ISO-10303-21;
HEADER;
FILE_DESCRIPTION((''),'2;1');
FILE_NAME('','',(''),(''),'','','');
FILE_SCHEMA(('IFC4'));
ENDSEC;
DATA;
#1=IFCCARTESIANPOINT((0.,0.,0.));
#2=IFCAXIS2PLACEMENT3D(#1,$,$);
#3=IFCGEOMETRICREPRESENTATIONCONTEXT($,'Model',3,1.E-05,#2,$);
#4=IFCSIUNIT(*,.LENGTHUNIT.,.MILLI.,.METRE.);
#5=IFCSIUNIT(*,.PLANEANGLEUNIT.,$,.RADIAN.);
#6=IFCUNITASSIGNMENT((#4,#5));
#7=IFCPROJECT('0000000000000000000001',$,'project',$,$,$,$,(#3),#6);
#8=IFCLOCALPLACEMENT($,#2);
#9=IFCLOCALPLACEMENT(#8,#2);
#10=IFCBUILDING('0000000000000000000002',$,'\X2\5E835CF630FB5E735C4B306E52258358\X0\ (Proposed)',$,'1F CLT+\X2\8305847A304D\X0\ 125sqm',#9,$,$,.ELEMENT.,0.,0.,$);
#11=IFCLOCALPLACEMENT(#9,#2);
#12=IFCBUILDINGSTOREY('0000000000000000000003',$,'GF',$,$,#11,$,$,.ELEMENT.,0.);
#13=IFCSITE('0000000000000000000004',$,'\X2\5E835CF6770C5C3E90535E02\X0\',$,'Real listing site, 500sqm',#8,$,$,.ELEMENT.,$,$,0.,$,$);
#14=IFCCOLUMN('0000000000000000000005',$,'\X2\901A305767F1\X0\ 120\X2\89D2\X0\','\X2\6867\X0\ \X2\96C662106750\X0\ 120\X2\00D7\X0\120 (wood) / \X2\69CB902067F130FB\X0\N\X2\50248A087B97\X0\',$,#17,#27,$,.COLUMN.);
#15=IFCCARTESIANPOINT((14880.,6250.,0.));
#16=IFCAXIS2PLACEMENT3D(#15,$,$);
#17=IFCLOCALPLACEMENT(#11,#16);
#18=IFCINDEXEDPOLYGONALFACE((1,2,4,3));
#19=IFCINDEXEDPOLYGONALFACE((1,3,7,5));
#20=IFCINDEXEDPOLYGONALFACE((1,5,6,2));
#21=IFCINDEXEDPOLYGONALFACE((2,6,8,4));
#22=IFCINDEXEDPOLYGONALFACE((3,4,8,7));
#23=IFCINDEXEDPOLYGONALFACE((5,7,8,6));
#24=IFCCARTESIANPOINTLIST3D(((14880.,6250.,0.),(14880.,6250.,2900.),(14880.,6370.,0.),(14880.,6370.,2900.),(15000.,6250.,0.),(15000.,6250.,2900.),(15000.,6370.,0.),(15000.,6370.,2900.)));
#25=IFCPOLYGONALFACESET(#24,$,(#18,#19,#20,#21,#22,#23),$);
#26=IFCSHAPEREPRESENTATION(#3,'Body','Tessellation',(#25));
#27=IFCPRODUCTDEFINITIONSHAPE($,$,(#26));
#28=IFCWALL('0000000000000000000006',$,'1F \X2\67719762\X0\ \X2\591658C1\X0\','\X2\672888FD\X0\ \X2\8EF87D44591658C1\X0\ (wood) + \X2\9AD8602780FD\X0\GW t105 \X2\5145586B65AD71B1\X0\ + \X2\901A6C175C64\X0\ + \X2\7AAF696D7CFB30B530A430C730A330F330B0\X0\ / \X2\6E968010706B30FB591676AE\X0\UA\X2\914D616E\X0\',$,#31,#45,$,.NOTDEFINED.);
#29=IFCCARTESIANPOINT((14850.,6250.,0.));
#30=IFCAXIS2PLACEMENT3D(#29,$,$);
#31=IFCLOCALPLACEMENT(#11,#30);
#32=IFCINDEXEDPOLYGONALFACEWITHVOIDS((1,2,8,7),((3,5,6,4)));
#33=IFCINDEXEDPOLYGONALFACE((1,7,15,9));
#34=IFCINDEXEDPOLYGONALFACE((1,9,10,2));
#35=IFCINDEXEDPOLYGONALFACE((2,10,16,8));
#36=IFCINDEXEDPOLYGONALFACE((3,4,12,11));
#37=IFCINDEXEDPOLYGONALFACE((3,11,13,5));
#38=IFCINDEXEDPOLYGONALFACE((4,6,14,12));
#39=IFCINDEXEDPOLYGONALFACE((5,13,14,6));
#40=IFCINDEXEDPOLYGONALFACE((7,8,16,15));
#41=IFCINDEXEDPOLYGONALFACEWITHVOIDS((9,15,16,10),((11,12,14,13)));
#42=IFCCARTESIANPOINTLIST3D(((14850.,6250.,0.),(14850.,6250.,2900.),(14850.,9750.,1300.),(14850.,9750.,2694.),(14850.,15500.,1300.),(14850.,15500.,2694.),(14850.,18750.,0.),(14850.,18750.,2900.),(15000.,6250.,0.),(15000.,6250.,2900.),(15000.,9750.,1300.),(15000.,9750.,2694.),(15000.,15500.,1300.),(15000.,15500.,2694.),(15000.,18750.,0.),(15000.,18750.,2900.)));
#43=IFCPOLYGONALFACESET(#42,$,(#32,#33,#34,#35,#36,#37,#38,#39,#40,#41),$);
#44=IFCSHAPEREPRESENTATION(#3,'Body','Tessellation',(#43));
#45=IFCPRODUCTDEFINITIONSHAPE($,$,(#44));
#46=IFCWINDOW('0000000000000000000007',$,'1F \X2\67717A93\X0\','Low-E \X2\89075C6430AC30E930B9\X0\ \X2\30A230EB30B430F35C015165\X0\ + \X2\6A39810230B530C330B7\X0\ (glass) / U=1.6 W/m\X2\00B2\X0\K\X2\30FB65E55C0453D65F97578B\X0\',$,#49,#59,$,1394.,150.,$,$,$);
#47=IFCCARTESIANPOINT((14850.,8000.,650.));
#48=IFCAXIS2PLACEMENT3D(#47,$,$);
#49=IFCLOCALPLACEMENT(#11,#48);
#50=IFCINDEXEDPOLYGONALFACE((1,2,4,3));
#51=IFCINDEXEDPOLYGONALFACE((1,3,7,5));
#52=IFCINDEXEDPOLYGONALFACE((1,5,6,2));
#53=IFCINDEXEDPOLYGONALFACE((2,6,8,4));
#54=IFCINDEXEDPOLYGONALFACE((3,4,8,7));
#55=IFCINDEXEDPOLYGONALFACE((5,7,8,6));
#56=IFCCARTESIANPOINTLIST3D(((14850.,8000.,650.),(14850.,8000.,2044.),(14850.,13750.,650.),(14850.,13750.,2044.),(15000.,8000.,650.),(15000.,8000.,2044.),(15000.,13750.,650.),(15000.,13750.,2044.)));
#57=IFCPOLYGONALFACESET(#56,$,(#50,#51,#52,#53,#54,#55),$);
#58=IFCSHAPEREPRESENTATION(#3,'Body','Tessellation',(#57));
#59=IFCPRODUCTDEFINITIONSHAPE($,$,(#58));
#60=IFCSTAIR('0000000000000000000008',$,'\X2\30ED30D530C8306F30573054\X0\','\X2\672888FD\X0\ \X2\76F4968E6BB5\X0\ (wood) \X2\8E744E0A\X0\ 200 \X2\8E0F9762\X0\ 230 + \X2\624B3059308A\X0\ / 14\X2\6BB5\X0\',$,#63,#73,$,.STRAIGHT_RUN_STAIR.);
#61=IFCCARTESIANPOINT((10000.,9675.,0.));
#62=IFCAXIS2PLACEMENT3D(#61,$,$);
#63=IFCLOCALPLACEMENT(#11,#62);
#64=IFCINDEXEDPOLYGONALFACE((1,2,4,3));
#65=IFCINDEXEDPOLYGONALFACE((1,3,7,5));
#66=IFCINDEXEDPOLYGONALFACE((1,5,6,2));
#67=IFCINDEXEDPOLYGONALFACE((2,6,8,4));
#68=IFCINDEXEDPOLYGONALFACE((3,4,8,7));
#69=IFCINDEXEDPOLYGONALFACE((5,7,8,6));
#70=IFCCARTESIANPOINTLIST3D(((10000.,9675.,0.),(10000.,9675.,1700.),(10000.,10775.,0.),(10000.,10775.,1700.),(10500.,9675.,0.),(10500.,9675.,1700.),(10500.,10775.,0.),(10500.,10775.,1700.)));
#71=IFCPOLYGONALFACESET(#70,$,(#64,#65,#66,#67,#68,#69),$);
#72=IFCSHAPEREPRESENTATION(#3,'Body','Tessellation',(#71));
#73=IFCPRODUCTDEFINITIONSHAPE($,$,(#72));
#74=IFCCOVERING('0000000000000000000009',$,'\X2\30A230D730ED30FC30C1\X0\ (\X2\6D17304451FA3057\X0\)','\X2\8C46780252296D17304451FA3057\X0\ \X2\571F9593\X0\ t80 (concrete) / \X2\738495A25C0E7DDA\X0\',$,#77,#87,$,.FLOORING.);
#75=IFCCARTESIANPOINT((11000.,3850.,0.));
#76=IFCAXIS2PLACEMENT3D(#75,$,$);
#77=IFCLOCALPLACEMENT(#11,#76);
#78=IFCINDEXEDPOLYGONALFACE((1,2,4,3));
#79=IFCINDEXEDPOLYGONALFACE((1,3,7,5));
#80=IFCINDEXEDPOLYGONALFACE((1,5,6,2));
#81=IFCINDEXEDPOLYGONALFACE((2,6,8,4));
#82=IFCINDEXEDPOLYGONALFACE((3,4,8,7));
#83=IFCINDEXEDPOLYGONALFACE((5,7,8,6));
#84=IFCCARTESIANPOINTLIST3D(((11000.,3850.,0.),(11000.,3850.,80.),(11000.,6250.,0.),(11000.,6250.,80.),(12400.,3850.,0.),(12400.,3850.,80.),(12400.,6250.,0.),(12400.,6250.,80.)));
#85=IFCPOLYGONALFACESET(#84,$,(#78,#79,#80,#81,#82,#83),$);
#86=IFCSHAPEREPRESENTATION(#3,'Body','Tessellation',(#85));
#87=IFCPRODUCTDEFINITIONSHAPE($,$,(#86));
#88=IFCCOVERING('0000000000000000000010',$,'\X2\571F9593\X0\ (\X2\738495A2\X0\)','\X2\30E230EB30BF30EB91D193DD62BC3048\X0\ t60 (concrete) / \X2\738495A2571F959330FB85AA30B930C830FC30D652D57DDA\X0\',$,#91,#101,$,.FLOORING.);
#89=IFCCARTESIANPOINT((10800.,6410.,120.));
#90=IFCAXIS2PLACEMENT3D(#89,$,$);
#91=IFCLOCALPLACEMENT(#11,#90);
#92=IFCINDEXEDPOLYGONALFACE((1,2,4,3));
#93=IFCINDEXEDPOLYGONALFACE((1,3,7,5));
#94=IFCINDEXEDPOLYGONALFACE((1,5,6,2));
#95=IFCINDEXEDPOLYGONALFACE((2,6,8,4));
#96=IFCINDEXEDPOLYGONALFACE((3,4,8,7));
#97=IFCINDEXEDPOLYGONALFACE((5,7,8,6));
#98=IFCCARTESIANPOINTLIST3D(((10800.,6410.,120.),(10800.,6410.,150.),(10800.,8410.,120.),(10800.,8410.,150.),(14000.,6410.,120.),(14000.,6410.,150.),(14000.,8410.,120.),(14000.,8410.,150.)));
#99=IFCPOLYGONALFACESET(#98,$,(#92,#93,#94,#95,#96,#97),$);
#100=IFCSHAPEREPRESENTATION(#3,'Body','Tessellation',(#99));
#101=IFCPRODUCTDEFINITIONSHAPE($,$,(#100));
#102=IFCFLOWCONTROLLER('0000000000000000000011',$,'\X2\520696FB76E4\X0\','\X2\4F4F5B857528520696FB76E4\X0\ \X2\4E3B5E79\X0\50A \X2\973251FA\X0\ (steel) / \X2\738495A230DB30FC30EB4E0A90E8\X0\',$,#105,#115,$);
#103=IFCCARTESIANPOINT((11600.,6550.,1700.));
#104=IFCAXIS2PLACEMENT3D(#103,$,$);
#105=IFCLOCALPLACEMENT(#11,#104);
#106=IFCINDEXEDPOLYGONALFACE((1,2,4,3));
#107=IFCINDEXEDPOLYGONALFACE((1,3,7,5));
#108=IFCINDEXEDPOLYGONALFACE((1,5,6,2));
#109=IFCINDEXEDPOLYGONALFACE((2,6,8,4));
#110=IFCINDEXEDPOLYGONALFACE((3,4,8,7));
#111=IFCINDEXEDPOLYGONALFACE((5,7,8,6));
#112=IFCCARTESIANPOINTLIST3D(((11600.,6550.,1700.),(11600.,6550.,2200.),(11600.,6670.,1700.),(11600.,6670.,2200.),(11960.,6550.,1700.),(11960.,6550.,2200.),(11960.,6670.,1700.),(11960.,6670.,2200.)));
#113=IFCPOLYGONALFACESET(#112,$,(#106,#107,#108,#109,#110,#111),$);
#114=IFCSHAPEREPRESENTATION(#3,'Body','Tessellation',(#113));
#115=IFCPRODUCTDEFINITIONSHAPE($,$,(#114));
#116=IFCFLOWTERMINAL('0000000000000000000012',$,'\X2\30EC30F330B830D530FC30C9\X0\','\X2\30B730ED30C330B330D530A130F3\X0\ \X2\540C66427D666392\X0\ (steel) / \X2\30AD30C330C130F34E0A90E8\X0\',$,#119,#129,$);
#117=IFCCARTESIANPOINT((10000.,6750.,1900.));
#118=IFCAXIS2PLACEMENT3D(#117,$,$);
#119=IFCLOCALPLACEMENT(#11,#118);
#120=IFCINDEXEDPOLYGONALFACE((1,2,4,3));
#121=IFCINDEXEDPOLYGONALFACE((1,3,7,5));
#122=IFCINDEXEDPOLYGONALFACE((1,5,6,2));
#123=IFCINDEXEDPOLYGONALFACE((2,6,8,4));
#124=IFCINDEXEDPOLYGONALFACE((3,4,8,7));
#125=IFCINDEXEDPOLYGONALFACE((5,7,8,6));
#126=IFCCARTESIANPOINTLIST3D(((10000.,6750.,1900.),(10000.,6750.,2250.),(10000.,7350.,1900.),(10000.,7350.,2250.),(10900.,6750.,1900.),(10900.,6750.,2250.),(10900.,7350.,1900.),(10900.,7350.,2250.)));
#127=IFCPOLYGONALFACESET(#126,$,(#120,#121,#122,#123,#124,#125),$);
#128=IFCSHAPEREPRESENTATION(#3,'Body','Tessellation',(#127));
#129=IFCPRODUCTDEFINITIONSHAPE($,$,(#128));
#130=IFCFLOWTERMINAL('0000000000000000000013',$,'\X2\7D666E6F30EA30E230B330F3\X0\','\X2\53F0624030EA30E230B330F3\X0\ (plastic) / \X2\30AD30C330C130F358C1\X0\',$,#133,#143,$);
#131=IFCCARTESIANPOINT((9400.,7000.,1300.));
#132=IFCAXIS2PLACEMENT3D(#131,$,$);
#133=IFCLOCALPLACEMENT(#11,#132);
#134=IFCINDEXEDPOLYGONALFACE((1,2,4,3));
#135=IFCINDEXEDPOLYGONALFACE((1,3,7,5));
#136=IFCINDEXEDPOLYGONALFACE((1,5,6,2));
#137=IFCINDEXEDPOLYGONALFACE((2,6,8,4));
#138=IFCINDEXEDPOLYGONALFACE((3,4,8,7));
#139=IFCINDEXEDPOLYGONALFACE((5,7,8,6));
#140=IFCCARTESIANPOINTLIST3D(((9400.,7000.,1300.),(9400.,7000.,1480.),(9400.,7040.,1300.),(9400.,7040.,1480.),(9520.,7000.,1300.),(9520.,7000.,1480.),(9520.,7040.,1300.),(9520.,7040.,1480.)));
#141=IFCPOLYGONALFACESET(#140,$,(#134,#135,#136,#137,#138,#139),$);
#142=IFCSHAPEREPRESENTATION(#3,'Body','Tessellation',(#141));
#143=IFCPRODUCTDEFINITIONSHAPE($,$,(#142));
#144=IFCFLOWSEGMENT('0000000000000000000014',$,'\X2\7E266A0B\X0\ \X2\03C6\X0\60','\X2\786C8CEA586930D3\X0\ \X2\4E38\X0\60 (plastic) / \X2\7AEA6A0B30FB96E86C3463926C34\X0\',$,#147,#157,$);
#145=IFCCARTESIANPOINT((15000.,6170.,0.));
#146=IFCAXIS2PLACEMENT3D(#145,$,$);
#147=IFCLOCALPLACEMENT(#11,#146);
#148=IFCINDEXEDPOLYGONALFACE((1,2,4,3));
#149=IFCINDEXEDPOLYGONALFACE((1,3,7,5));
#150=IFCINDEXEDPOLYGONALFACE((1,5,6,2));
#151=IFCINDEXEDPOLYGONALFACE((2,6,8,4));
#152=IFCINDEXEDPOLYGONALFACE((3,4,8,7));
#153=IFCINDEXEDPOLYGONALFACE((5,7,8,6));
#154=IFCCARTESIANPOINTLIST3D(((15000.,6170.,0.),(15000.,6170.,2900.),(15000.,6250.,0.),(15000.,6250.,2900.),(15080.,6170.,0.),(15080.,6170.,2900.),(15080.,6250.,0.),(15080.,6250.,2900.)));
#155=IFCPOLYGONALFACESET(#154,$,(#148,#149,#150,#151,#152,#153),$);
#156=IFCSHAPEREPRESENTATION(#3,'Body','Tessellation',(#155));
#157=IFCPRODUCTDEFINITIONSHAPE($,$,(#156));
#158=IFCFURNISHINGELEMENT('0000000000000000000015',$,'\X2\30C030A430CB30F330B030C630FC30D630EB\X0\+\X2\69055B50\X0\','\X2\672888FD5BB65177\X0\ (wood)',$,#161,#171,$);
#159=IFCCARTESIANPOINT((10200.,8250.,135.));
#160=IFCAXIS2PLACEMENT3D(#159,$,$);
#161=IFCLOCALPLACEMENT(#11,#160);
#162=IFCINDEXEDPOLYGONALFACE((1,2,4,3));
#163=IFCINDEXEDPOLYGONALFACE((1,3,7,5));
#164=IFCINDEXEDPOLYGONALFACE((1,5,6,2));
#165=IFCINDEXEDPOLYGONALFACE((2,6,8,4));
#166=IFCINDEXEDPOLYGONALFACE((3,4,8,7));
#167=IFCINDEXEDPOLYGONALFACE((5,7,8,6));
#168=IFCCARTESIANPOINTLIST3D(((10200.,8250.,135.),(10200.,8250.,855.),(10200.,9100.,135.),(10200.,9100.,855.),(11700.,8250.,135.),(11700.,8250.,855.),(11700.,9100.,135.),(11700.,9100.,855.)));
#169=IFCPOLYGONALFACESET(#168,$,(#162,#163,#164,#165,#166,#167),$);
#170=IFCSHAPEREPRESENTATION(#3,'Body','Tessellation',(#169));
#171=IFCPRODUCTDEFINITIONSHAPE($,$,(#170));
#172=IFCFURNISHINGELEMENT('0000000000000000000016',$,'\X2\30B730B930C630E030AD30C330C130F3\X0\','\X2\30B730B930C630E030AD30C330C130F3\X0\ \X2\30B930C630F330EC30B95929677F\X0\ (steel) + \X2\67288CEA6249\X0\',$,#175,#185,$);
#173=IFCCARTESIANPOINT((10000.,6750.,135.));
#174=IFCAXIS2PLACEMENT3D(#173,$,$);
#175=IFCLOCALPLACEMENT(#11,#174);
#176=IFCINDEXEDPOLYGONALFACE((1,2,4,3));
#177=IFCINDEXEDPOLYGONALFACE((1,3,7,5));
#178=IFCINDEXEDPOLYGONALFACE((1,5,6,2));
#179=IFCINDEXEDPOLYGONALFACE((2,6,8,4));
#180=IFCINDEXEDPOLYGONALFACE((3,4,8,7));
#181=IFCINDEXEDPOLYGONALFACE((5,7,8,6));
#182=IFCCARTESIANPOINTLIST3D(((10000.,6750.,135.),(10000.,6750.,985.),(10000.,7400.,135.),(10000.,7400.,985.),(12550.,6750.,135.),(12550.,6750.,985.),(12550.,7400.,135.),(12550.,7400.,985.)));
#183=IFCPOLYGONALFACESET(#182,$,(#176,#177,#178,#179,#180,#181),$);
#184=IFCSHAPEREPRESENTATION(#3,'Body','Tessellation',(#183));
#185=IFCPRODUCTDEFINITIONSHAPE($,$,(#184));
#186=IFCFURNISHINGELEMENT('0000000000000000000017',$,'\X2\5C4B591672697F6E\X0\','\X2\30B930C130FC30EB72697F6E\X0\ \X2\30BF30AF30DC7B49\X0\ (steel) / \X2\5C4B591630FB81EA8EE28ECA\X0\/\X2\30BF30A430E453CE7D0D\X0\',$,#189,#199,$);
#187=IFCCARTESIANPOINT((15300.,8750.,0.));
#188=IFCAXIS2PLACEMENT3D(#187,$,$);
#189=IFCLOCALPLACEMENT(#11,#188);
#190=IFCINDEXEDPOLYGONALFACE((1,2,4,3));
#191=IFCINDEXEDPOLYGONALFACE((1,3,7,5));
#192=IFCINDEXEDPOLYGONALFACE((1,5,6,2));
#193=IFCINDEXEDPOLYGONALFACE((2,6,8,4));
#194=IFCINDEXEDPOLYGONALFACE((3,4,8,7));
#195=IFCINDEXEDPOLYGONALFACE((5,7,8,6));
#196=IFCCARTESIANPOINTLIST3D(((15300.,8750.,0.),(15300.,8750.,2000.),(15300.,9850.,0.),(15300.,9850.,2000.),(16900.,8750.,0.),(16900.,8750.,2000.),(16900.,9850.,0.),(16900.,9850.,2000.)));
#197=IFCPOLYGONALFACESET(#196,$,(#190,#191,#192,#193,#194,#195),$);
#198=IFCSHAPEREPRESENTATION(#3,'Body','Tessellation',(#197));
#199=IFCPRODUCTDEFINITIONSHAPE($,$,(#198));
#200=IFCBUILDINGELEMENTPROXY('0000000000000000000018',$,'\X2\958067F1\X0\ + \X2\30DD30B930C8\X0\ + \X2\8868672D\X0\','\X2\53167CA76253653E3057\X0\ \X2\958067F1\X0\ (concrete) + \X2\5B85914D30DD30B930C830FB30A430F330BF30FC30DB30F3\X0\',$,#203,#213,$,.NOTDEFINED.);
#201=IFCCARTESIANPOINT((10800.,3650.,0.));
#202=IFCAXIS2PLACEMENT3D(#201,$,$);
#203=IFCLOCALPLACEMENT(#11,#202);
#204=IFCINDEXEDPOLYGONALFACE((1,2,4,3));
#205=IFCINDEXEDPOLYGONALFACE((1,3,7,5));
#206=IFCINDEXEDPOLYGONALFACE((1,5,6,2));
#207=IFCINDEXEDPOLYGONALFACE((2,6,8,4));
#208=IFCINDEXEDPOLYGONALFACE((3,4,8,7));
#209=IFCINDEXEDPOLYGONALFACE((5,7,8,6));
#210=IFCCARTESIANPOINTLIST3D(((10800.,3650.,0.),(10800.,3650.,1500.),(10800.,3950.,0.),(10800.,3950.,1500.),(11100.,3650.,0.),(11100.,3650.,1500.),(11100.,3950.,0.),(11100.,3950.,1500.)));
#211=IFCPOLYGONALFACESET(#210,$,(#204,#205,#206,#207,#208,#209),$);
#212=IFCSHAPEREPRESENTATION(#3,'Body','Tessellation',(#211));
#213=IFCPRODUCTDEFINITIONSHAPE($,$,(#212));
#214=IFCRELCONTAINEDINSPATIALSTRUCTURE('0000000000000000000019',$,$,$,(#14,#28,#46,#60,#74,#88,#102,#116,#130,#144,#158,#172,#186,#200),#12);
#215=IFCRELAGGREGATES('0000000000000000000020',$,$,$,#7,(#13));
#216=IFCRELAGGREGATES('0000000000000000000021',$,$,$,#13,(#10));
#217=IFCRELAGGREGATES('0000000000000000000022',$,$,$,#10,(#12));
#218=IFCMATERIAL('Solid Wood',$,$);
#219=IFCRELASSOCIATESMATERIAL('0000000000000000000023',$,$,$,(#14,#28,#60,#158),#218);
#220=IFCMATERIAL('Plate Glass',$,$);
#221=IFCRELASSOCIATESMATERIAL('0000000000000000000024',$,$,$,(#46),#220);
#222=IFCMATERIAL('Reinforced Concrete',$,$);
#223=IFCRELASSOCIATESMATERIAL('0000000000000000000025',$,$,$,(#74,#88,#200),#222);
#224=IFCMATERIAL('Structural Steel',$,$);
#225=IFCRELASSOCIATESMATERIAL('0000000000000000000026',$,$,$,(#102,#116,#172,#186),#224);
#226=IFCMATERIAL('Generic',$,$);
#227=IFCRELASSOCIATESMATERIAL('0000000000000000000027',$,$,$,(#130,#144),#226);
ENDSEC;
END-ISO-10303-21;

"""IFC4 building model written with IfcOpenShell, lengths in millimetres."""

from ifc_helpers import new_model, si_unit, frame, frame_2d, origin, place, context, project, spatial, rectangle, extrude, material, element, fill, save


model = new_model("IFC4")

# Units and contexts
model_context = context("Model", 3, precision=1e-05, world=origin())
ifc_project = project(units=[si_unit("LENGTHUNIT", "METRE", prefix="MILLI"), si_unit("PLANEANGLEUNIT", "RADIAN")], contexts=[model_context])

# Site, building, storey
site_placement = place(None, origin())
site = spatial("IfcSite", under=ifc_project, at=site_placement, Name="広島県尾道市", ObjectType="Real listing site, 500sqm", CompositionType="ELEMENT", RefElevation=0.0)
building_placement = place(site_placement, origin())
building = spatial("IfcBuilding", under=site, at=building_placement, Name="広島・平屋の別荘 (Proposed)", ObjectType="1F CLT+茅葺き 125sqm", CompositionType="ELEMENT", ElevationOfRefHeight=0.0, ElevationOfTerrain=0.0)
storey_placement = place(building_placement, origin())
storey = spatial("IfcBuildingStorey", under=building, at=storey_placement, Name="GF", CompositionType="ELEMENT", Elevation=0.0)

# Column
ifc_material_1 = material(Name="Solid Wood")
column_1_placement = place(storey_placement, frame((14880.0, 6250.0, 0.0)))
element("IfcColumn", 1, at=column_1_placement, inside=storey, material=ifc_material_1, Name="通し柱 120角", Description="桧 集成材 120×120 (wood) / 構造柱・N値計算", PredefinedType="COLUMN", context=model_context, shape_type="SweptSolid", body=[
    extrude(rectangle(XDim=120.0, YDim=120.0, at=frame_2d((60.0, 60.0))), frame((14880.0, 6250.0, 0.0)), (0.0, 0.0, 1.0), 2900.0),
])

# Wall, opening, window
wall_1_placement = place(storey_placement, frame((14850.0, 6250.0, 0.0)))
wall_1 = element("IfcWall", 2, at=wall_1_placement, inside=storey, material=ifc_material_1, Name="1F 東面 外壁", Description="木製 軸組外壁 (wood) + 高性能GW t105 充填断熱 + 通気層 + 窯業系サイディング / 準耐火・外皮UA配慮", PredefinedType="NOTDEFINED", context=model_context, shape_type="SweptSolid", body=[
    extrude(rectangle(XDim=150.0, YDim=12500.0, at=frame_2d((75.0, 6250.0))), frame((14850.0, 6250.0, 0.0)), (0.0, 0.0, 1.0), 2900.0),
])
opening_placement = place(storey_placement, frame((14850.0, 8000.0, 650.0)))
opening = element("IfcOpeningElement", 3, at=opening_placement, cuts=wall_1, PredefinedType="NOTDEFINED", context=model_context, shape_type="SweptSolid", body=[
    extrude(rectangle(XDim=150.0, YDim=5750.0, at=frame_2d((75.0, 2875.0))), frame((14850.0, 8000.0, 650.0)), (0.0, 0.0, 1.0), 1394.0),
])
ifc_material_2 = material(Name="Plate Glass")
window_placement = place(storey_placement, frame((14850.0, 8000.0, 650.0)))
window = element("IfcWindow", 4, at=window_placement, inside=storey, material=ifc_material_2, Name="1F 東窓", Description="Low-E 複層ガラス アルゴン封入 + 樹脂サッシ (glass) / U=1.6 W/m²K・日射取得型", OverallHeight=1394.0, OverallWidth=150.0, context=model_context, shape_type="SweptSolid", body=[
    extrude(rectangle(XDim=150.0, YDim=5750.0, at=frame_2d((75.0, 2875.0))), frame((14850.0, 8000.0, 650.0)), (0.0, 0.0, 1.0), 1394.0),
])
fill(opening, window)

# Stair
stair_placement = place(storey_placement, frame((10000.0, 9675.0, 0.0)))
element("IfcStair", 5, at=stair_placement, inside=storey, material=ifc_material_1, Name="ロフトはしご", Description="木製 直階段 (wood) 蹴上 200 踏面 230 + 手すり / 14段", PredefinedType="STRAIGHT_RUN_STAIR", context=model_context, shape_type="SweptSolid", body=[
    extrude(rectangle(XDim=500.0, YDim=1100.0, at=frame_2d((250.0, 550.0))), frame((10000.0, 9675.0, 0.0)), (0.0, 0.0, 1.0), 1700.0),
])

# Coverings
ifc_material_3 = material(Name="Reinforced Concrete")
covering_1_placement = place(storey_placement, frame((11000.0, 3850.0, 0.0)))
element("IfcCovering", 6, at=covering_1_placement, inside=storey, material=ifc_material_3, Name="アプローチ (洗い出し)", Description="豆砂利洗い出し 土間 t80 (concrete) / 玄関導線", PredefinedType="FLOORING", context=model_context, shape_type="SweptSolid", body=[
    extrude(rectangle(XDim=1400.0, YDim=2400.0, at=frame_2d((700.0, 1200.0))), frame((11000.0, 3850.0, 0.0)), (0.0, 0.0, 1.0), 80.0),
])
covering_2_placement = place(storey_placement, frame((10800.0, 6410.0, 120.0)))
element("IfcCovering", 7, at=covering_2_placement, inside=storey, material=ifc_material_3, Name="土間 (玄関)", Description="モルタル金鏝押え t60 (concrete) / 玄関土間・薪ストーブ動線", PredefinedType="FLOORING", context=model_context, shape_type="SweptSolid", body=[
    extrude(rectangle(XDim=3200.0, YDim=2000.0, at=frame_2d((1600.0, 1000.0))), frame((10800.0, 6410.0, 120.0)), (0.0, 0.0, 1.0), 30.0),
])

# Flow controller
ifc_material_4 = material(Name="Structural Steel")
flow_controller_placement = place(storey_placement, frame((11600.0, 6550.0, 1700.0)))
element("IfcFlowController", 8, at=flow_controller_placement, inside=storey, material=ifc_material_4, Name="分電盤", Description="住宅用分電盤 主幹50A 露出 (steel) / 玄関ホール上部", context=model_context, shape_type="SweptSolid", body=[
    extrude(rectangle(XDim=360.0, YDim=120.0, at=frame_2d((180.0, 60.0))), frame((11600.0, 6550.0, 1700.0)), (0.0, 0.0, 1.0), 500.0),
])

# Flow terminals
flow_terminal_1_placement = place(storey_placement, frame((10000.0, 6750.0, 1900.0)))
element("IfcFlowTerminal", 9, at=flow_terminal_1_placement, inside=storey, material=ifc_material_4, Name="レンジフード", Description="シロッコファン 同時給排 (steel) / キッチン上部", context=model_context, shape_type="SweptSolid", body=[
    extrude(rectangle(XDim=900.0, YDim=600.0, at=frame_2d((450.0, 300.0))), frame((10000.0, 6750.0, 1900.0)), (0.0, 0.0, 1.0), 350.0),
])
ifc_material_5 = material(Name="Generic")
flow_terminal_2_placement = place(storey_placement, frame((9400.0, 7000.0, 1300.0)))
element("IfcFlowTerminal", 10, at=flow_terminal_2_placement, inside=storey, material=ifc_material_5, Name="給湯リモコン", Description="台所リモコン (plastic) / キッチン壁", context=model_context, shape_type="SweptSolid", body=[
    extrude(rectangle(XDim=120.0, YDim=40.0, at=frame_2d((60.0, 20.0))), frame((9400.0, 7000.0, 1300.0)), (0.0, 0.0, 1.0), 180.0),
])

# Flow segment
flow_segment_placement = place(storey_placement, frame((15000.0, 6170.0, 0.0)))
element("IfcFlowSegment", 11, at=flow_segment_placement, inside=storey, material=ifc_material_5, Name="縦樋 φ60", Description="硬質塩ビ 丸60 (plastic) / 竪樋・雨水排水", context=model_context, shape_type="SweptSolid", body=[
    extrude(rectangle(XDim=80.0, YDim=80.0, at=frame_2d((40.0, 40.0))), frame((15000.0, 6170.0, 0.0)), (0.0, 0.0, 1.0), 2900.0),
])

# Furnishing elements
furnishing_1_placement = place(storey_placement, frame((10200.0, 8250.0, 135.0)))
element("IfcFurnishingElement", 12, at=furnishing_1_placement, inside=storey, material=ifc_material_1, Name="ダイニングテーブル+椅子", Description="木製家具 (wood)", context=model_context, shape_type="SweptSolid", body=[
    extrude(rectangle(XDim=1500.0, YDim=850.0, at=frame_2d((750.0, 425.0))), frame((10200.0, 8250.0, 135.0)), (0.0, 0.0, 1.0), 720.0),
])
furnishing_2_placement = place(storey_placement, frame((10000.0, 6750.0, 135.0)))
element("IfcFurnishingElement", 13, at=furnishing_2_placement, inside=storey, material=ifc_material_4, Name="システムキッチン", Description="システムキッチン ステンレス天板 (steel) + 木質扉", context=model_context, shape_type="SweptSolid", body=[
    extrude(rectangle(XDim=2550.0, YDim=650.0, at=frame_2d((1275.0, 325.0))), frame((10000.0, 6750.0, 135.0)), (0.0, 0.0, 1.0), 850.0),
])
furnishing_3_placement = place(storey_placement, frame((15300.0, 8750.0, 0.0)))
element("IfcFurnishingElement", 14, at=furnishing_3_placement, inside=storey, material=ifc_material_4, Name="屋外物置", Description="スチール物置 タクボ等 (steel) / 屋外・自転車/タイヤ収納", context=model_context, shape_type="SweptSolid", body=[
    extrude(rectangle(XDim=1600.0, YDim=1100.0, at=frame_2d((800.0, 550.0))), frame((15300.0, 8750.0, 0.0)), (0.0, 0.0, 1.0), 2000.0),
])

# Building element proxy
proxy_placement = place(storey_placement, frame((10800.0, 3650.0, 0.0)))
element("IfcBuildingElementProxy", 15, at=proxy_placement, inside=storey, material=ifc_material_3, Name="門柱 + ポスト + 表札", Description="化粧打放し 門柱 (concrete) + 宅配ポスト・インターホン", PredefinedType="NOTDEFINED", context=model_context, shape_type="SweptSolid", body=[
    extrude(rectangle(XDim=300.0, YDim=300.0, at=frame_2d((150.0, 150.0))), frame((10800.0, 3650.0, 0.0)), (0.0, 0.0, 1.0), 1500.0),
])

save(model, "model.ifc")
